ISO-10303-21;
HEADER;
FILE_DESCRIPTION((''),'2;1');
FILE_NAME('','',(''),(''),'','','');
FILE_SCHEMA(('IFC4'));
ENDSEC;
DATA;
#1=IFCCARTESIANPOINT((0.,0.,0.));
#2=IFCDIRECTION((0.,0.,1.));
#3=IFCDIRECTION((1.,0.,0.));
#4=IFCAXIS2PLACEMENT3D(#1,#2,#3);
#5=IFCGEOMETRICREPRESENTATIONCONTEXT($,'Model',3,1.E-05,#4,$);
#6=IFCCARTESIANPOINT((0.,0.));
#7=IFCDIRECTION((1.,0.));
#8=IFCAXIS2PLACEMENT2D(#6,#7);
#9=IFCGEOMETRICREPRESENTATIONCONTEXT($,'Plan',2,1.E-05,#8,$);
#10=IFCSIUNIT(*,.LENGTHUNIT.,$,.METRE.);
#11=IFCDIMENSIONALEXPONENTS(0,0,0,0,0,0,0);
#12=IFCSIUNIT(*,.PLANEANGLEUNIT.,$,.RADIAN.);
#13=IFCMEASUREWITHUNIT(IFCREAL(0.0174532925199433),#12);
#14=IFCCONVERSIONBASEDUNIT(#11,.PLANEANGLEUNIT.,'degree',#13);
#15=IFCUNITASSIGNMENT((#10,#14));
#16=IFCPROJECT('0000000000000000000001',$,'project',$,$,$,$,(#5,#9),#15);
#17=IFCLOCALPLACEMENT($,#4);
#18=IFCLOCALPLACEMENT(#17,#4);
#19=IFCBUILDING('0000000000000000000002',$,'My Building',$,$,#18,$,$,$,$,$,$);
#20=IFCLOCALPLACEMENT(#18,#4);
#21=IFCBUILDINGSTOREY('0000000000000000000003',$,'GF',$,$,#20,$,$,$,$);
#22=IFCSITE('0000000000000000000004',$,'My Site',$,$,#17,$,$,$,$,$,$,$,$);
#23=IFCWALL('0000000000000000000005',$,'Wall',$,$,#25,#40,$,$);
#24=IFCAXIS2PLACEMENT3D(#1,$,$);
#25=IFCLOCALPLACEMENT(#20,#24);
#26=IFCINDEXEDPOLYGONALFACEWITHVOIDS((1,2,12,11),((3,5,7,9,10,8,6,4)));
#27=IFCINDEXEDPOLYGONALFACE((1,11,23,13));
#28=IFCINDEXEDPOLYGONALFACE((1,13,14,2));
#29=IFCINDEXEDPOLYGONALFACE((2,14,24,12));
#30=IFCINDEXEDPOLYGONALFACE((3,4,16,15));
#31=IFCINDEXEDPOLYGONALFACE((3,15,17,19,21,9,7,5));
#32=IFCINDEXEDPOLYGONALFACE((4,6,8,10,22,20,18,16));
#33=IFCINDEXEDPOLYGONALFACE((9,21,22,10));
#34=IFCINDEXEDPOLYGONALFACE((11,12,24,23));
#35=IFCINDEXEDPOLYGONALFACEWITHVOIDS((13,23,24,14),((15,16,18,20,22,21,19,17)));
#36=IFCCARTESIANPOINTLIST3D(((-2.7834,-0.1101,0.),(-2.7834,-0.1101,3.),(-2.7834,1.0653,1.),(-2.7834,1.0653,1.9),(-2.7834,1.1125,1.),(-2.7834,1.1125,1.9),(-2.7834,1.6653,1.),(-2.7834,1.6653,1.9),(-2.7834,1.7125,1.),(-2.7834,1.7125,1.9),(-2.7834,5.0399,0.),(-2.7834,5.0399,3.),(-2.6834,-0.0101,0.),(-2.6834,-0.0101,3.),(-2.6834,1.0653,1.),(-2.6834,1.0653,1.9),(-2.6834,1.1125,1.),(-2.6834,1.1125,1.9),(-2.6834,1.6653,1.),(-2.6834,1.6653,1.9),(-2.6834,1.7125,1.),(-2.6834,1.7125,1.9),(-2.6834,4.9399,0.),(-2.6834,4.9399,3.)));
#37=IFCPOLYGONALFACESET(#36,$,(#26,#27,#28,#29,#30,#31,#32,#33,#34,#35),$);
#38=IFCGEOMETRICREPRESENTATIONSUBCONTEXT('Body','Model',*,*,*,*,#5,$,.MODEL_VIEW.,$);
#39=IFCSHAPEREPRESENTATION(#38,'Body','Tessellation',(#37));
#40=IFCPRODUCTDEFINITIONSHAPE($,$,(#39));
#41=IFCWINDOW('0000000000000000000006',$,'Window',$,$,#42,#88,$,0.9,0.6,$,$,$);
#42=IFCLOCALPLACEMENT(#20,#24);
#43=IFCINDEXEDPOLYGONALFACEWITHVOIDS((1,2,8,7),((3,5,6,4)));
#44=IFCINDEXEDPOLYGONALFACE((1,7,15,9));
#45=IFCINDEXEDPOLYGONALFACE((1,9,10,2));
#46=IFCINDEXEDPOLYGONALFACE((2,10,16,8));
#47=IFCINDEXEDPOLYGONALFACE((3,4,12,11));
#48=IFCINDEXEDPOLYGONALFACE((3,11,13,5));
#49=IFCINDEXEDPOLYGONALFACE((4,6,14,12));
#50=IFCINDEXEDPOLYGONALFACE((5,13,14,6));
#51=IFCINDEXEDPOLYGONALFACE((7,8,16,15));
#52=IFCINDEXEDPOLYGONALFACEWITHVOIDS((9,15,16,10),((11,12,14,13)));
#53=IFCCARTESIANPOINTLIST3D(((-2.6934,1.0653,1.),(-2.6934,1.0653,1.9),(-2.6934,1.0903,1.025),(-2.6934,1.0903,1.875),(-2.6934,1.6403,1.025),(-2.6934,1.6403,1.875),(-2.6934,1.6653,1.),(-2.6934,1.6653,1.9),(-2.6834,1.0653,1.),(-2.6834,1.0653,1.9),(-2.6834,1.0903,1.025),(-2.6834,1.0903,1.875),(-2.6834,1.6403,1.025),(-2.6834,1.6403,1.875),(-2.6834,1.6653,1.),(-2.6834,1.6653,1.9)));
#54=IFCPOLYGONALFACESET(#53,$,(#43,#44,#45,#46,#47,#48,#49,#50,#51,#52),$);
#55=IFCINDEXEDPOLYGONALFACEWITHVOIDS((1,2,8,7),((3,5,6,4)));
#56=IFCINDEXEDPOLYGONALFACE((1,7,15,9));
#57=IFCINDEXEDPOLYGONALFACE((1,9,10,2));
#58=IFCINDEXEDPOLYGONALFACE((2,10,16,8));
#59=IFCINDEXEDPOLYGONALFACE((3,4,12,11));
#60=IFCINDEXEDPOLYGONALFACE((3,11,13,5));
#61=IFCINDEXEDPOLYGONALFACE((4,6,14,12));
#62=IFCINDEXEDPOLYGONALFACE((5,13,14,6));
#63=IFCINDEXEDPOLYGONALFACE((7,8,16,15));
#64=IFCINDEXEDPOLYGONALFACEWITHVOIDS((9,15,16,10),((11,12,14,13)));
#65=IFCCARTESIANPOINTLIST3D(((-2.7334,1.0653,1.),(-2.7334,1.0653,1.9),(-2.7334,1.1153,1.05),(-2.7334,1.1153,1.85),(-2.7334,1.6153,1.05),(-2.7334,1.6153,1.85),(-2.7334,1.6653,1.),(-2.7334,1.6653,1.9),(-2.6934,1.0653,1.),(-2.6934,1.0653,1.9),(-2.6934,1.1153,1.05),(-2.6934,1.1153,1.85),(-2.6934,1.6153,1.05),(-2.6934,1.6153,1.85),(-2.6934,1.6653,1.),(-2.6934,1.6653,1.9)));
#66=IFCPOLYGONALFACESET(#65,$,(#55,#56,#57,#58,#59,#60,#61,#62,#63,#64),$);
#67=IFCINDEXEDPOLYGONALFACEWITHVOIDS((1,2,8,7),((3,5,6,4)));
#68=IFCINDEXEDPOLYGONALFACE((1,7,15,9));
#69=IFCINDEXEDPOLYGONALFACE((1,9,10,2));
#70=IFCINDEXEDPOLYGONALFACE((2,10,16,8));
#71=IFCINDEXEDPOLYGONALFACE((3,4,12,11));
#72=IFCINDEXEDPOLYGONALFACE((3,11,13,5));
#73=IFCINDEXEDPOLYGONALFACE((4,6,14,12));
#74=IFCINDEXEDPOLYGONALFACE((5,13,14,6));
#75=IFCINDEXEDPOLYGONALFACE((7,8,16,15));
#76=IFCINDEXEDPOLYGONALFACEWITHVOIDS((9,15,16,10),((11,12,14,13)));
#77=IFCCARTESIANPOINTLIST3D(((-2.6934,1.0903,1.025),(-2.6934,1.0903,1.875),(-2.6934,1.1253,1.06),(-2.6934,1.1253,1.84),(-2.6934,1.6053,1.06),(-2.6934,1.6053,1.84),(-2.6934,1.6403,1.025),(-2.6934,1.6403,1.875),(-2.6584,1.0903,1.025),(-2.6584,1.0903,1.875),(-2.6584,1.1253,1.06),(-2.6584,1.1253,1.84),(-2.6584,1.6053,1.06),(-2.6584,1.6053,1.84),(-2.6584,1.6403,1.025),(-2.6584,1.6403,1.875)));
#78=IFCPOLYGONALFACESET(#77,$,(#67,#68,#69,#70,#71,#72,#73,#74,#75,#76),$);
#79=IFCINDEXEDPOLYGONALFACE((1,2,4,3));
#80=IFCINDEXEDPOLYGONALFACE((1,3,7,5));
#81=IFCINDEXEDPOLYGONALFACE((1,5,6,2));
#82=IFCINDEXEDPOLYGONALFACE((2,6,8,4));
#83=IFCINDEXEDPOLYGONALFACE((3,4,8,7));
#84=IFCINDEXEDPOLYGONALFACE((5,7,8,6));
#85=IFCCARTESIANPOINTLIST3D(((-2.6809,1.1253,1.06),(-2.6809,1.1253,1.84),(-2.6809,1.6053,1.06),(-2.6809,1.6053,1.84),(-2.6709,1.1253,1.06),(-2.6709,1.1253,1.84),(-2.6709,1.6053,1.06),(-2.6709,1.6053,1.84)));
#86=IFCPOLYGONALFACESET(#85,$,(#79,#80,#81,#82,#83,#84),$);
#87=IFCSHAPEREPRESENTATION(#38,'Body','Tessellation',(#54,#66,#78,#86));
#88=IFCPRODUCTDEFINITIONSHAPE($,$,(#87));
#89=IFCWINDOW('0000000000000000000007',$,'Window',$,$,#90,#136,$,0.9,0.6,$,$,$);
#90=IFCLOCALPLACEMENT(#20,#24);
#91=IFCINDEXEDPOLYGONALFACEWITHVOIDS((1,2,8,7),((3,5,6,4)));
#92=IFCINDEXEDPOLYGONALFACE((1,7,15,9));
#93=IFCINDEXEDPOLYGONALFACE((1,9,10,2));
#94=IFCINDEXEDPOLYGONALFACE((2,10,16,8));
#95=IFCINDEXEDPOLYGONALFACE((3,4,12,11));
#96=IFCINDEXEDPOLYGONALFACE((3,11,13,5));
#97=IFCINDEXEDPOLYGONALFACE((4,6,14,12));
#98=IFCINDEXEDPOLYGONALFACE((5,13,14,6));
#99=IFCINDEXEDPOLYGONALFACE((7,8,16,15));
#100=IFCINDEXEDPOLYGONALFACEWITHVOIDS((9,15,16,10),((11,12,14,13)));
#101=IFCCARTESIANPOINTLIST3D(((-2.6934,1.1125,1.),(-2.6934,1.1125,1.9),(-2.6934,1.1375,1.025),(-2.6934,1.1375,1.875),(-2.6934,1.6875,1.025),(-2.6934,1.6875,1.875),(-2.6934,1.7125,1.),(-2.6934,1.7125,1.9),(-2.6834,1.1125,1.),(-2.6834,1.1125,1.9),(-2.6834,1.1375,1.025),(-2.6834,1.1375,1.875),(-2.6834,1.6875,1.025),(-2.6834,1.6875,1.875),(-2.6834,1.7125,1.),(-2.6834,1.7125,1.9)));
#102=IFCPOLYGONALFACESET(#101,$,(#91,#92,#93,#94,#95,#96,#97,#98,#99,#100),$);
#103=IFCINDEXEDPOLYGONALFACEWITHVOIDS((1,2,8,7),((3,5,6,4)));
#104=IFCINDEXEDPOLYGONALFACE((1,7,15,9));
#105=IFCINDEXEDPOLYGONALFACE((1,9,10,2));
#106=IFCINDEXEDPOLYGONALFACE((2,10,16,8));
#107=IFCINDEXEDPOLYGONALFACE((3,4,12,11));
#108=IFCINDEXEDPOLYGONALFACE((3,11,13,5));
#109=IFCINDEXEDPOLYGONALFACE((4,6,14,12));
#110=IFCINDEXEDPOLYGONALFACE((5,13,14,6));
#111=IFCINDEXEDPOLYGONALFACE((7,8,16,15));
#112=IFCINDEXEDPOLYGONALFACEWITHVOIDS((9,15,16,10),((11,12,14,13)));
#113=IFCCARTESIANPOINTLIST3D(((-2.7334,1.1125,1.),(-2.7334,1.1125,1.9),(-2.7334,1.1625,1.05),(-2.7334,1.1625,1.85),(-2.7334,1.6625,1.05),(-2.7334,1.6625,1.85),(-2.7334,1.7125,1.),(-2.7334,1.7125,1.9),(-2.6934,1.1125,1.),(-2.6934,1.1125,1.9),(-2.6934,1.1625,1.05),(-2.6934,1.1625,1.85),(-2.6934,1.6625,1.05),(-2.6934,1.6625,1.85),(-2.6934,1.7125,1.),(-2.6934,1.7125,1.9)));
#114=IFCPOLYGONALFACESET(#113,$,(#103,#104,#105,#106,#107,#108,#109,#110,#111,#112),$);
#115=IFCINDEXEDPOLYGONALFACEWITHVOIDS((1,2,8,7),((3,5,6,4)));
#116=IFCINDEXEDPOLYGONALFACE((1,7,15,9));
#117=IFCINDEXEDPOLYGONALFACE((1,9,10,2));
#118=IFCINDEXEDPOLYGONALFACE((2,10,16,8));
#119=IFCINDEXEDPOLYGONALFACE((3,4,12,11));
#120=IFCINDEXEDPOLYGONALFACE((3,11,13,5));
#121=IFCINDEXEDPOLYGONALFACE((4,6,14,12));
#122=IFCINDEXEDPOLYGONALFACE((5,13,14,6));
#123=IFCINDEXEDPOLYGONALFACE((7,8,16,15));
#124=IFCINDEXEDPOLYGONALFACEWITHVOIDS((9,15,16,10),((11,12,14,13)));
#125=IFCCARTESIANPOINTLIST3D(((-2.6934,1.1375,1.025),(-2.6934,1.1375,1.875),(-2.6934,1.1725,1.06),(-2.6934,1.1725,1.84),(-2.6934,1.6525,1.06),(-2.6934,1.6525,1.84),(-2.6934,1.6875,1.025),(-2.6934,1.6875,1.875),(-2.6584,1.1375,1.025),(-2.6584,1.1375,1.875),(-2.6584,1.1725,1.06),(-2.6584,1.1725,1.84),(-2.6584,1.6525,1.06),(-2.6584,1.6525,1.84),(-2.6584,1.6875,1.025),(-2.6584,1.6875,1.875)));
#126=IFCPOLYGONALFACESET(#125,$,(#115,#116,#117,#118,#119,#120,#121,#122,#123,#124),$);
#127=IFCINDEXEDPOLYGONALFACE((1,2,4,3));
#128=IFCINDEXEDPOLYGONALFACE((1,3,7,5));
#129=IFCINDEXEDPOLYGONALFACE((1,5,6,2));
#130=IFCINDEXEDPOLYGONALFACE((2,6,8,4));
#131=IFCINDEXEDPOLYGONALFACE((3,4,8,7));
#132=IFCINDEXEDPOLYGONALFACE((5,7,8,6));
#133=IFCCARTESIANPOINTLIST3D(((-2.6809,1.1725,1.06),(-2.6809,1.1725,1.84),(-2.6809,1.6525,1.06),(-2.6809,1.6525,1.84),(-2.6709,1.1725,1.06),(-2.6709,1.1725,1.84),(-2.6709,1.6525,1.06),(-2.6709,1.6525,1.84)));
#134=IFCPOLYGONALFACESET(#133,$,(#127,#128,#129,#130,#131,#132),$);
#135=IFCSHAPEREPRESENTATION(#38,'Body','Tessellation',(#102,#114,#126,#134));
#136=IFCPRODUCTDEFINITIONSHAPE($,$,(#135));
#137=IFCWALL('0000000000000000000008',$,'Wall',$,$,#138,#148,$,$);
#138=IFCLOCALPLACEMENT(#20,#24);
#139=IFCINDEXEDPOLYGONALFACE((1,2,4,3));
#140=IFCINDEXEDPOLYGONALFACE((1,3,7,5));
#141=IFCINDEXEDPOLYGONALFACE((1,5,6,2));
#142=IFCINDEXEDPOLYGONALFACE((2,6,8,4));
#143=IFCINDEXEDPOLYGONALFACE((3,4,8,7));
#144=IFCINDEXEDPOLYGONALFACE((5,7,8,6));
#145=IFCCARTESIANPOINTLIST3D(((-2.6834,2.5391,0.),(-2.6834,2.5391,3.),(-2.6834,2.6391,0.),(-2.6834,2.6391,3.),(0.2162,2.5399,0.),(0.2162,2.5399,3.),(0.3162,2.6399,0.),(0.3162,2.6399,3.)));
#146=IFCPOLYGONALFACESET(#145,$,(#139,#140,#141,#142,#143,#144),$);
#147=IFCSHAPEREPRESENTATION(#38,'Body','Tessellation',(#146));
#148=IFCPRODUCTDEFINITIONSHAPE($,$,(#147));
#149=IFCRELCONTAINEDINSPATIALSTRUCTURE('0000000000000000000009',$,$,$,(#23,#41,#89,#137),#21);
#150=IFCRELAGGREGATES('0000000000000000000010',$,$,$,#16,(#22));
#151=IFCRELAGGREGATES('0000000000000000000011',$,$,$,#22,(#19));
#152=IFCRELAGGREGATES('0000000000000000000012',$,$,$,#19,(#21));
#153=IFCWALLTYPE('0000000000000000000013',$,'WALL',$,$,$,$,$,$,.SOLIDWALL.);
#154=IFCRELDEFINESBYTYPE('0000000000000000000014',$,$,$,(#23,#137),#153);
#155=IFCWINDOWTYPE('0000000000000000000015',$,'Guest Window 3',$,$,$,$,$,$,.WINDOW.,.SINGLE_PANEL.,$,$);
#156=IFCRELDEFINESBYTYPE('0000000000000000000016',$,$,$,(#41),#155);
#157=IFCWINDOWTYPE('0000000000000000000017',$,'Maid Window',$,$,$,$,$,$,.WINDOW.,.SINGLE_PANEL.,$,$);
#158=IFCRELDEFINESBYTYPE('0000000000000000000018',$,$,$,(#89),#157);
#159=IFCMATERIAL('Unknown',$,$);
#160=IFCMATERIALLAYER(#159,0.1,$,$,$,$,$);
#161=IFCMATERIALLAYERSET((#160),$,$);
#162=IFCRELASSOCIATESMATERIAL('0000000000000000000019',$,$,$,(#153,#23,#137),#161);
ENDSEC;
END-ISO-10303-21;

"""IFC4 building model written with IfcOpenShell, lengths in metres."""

from ifc_helpers import new_model, entity, si_unit, converted_unit, frame, origin_with_axes, origin_2d_with_axis, place, context, subcontext, project, spatial, line, indexed_curve, outline, extrude, shape, source, transform, mapped, material, layer, layer_set, layer_usage, type_object, type_shapes, element, fill, save


model = new_model("IFC4")

# Units and contexts
model_context = context("Model", 3, precision=1e-05, world=origin_with_axes())
plan_context = context("Plan", 2, precision=1e-05, world=origin_2d_with_axis())
body_context_1 = subcontext(model_context, "Body", "Model", "MODEL_VIEW")
body_context_2 = subcontext(plan_context, "Body", "Plan", "PLAN_VIEW")
ifc_project = project(units=[si_unit("LENGTHUNIT", "METRE"), converted_unit("PLANEANGLEUNIT", "degree", entity("IfcReal", 0.0174532925199433), si_unit("PLANEANGLEUNIT", "RADIAN"), dimensions=[0, 0, 0, 0, 0, 0, 0])], contexts=[model_context, plan_context])

# Site, building, storey
site_placement = place(None, origin_with_axes())
site = spatial("IfcSite", under=ifc_project, at=site_placement, Name="My Site")
building_placement = place(site_placement, origin_with_axes())
building = spatial("IfcBuilding", under=site, at=building_placement, Name="My Building")
storey_placement = place(building_placement, origin_with_axes())
storey = spatial("IfcBuildingStorey", under=building, at=storey_placement, Name="GF")

# Shared definitions
ifc_material = material(Name="Unknown")
ifc_layer = layer(ifc_material, 0.1)
ifc_layer_set = layer_set([ifc_layer])
wall_type = type_object("IfcWallType", Name="WALL", PredefinedType="SOLIDWALL", material=ifc_layer_set)

# Wall, openings, windows
shared_shape_1 = source(origin_with_axes(), body_context_1, "Body", "SweptSolid", [
    extrude(outline(indexed_curve([(0.0, 0.0), (0.6, 0.0), (0.6, 0.9), (0.0, 0.9)], segments=[line(1, 2, 3, 4, 1)])), frame((0.0, -0.6, 0.0), z_axis=(0.0, -1.0, 0.0), x_axis=(1.0, 0.0, 0.0)), (0.0, 0.0, -1.0), 1.2),
])
window_type_1 = type_object("IfcWindowType", Name="Maid Window", PartitioningType="SINGLE_PANEL", PredefinedType="WINDOW")
shared_shape_2 = source(origin_with_axes(), body_context_1, "Body", "SweptSolid", [
    extrude(outline(indexed_curve([(0.0, 0.0), (0.6, 0.0), (0.6, 0.9), (0.0, 0.9)], segments=[line(1, 2, 3, 4, 1)]), holes=[indexed_curve([(0.025, 0.025), (0.575, 0.025), (0.575, 0.875), (0.025, 0.875)], segments=[line(1, 2, 3, 4, 1)])]), frame((0.0, 0.09, 0.0), z_axis=(0.0, -1.0, 0.0), x_axis=(1.0, 0.0, 0.0)), (0.0, 0.0, -1.0), 0.01),
    extrude(outline(indexed_curve([(0.0, 0.0), (0.6, 0.0), (0.6, 0.9), (0.0, 0.9)], segments=[line(1, 2, 3, 4, 1)]), holes=[indexed_curve([(0.05, 0.05), (0.55, 0.05), (0.55, 0.85), (0.05, 0.85)], segments=[line(1, 2, 3, 4, 1)])]), frame((0.0, 0.05, 0.0), z_axis=(0.0, -1.0, 0.0), x_axis=(1.0, 0.0, 0.0)), (0.0, 0.0, -1.0), 0.04),
    extrude(outline(indexed_curve([(0.0, 0.0), (0.55, 0.0), (0.55, 0.85), (0.0, 0.85)], segments=[line(1, 2, 3, 4, 1)]), holes=[indexed_curve([(0.035, 0.035), (0.515, 0.035), (0.515, 0.815), (0.035, 0.815)], segments=[line(1, 2, 3, 4, 1)])]), frame((0.025, 0.09, 0.025), z_axis=(0.0, -1.0, 0.0), x_axis=(1.0, 0.0, 0.0)), (0.0, 0.0, -1.0), 0.035),
    extrude(outline(indexed_curve([(0.035, 0.035), (0.515, 0.035), (0.515, 0.815), (0.035, 0.815)], segments=[line(1, 2, 3, 4, 1)])), frame((0.025, 0.1025, 0.025), z_axis=(0.0, -1.0, 0.0), x_axis=(1.0, 0.0, 0.0)), (0.0, 0.0, -1.0), 0.01),
])
shared_shape_3 = source(origin_with_axes(), body_context_2, "Body", "Curve2D", [
    entity("IfcIndexedPolyCurve", entity("IfcCartesianPointList2D", [[0.05, 0.05], [0.55, 0.05]])),
    entity("IfcIndexedPolyCurve", entity("IfcCartesianPointList2D", [[0.0, 0.1], [0.025, 0.1], [0.025, 0.09], [0.05, 0.09], [0.05, 0.05], [0.0, 0.05]]), [entity("IfcLineIndex", [1, 2, 3, 4, 5, 6, 1])]),
    entity("IfcIndexedPolyCurve", entity("IfcCartesianPointList2D", [[0.6, 0.1], [0.575, 0.1], [0.575, 0.09], [0.55, 0.09], [0.55, 0.05], [0.6, 0.05]]), [entity("IfcLineIndex", [1, 2, 3, 4, 5, 6, 1])]),
    entity("IfcIndexedPolyCurve", entity("IfcCartesianPointList2D", [[0.025, 0.09], [0.06, 0.09], [0.06, 0.125], [0.025, 0.125]]), [entity("IfcLineIndex", [1, 2, 3, 4, 1])]),
    entity("IfcIndexedPolyCurve", entity("IfcCartesianPointList2D", [[0.575, 0.09], [0.54, 0.09], [0.54, 0.125], [0.575, 0.125]]), [entity("IfcLineIndex", [1, 2, 3, 4, 1])]),
    entity("IfcIndexedPolyCurve", entity("IfcCartesianPointList2D", [[0.06, 0.09], [0.54, 0.09]])),
    entity("IfcIndexedPolyCurve", entity("IfcCartesianPointList2D", [[0.06, 0.125], [0.54, 0.125]])),
    entity("IfcIndexedPolyCurve", entity("IfcCartesianPointList2D", [[0.06, 0.1075], [0.54, 0.1075]])),
])
type_shapes(window_type_1, [shared_shape_2, shared_shape_3])
ifc_layer_usage_1 = layer_usage(ifc_layer_set, "AXIS2", "POSITIVE", 0.0)
wall_1_placement = place(storey_placement, frame((-2.7834, 5.0399, 0.0), z_axis=(0.0, 0.0, 1.0), x_axis=(0.0, -1.0, 0.0)))
wall_1 = element("IfcWall", 1, at=wall_1_placement, inside=storey, type_object=wall_type, material=ifc_layer_usage_1, Name="Wall", context=body_context_1, shape_type="SweptSolid", body=[
    extrude(outline(indexed_curve([(0.0, 0.0), (0.1, 0.1), (5.05, 0.1), (5.15, 0.0)], segments=[line(1, 2, 3, 4, 1)])), origin_with_axes(), (0.0, 0.0, 1.0), 3.0),
])
opening_1_placement = place(wall_1_placement, frame((3.3274, 0.0, 1.0), z_axis=(0.0, 0.0, 1.0), x_axis=(1.0, 0.0, 0.0)))
opening_1 = element("IfcOpeningElement", 2, at=opening_1_placement, cuts=wall_1, PredefinedType="OPENING", context=body_context_1, shape_type="MappedRepresentation", body=[
    mapped(shared_shape_1, transform((0.0, 0.0, 0.0), x_axis=(1.0, 0.0, 0.0), y_axis=(0.0, 1.0, 0.0), z_axis=(0.0, 0.0, 1.0), scale=1.0)),
])
shared_shape_4 = source(origin_with_axes(), body_context_1, "Body", "SweptSolid", [
    extrude(outline(indexed_curve([(0.0, 0.0), (0.6, 0.0), (0.6, 0.9), (0.0, 0.9)], segments=[line(1, 2, 3, 4, 1)])), frame((0.0, -0.6, 0.0), z_axis=(0.0, -1.0, 0.0), x_axis=(1.0, 0.0, 0.0)), (0.0, 0.0, -1.0), 1.2),
])
opening_2_placement = place(wall_1_placement, frame((3.3746, 0.0, 1.0), z_axis=(0.0, 0.0, 1.0), x_axis=(1.0, 0.0, 0.0)))
opening_2 = element("IfcOpeningElement", 3, at=opening_2_placement, cuts=wall_1, PredefinedType="OPENING", context=body_context_1, shape_type="MappedRepresentation", body=[
    mapped(shared_shape_4, transform((0.0, 0.0, 0.0), x_axis=(1.0, 0.0, 0.0), y_axis=(0.0, 1.0, 0.0), z_axis=(0.0, 0.0, 1.0), scale=1.0)),
])
window_type_2 = type_object("IfcWindowType", Name="Guest Window 3", PartitioningType="SINGLE_PANEL", PredefinedType="WINDOW")
shared_shape_5 = source(origin_with_axes(), body_context_1, "Body", "SweptSolid", [
    extrude(outline(indexed_curve([(0.0, 0.0), (0.6, 0.0), (0.6, 0.9), (0.0, 0.9)], segments=[line(1, 2, 3, 4, 1)]), holes=[indexed_curve([(0.025, 0.025), (0.575, 0.025), (0.575, 0.875), (0.025, 0.875)], segments=[line(1, 2, 3, 4, 1)])]), frame((0.0, 0.09, 0.0), z_axis=(0.0, -1.0, 0.0), x_axis=(1.0, 0.0, 0.0)), (0.0, 0.0, -1.0), 0.01),
    extrude(outline(indexed_curve([(0.0, 0.0), (0.6, 0.0), (0.6, 0.9), (0.0, 0.9)], segments=[line(1, 2, 3, 4, 1)]), holes=[indexed_curve([(0.05, 0.05), (0.55, 0.05), (0.55, 0.85), (0.05, 0.85)], segments=[line(1, 2, 3, 4, 1)])]), frame((0.0, 0.05, 0.0), z_axis=(0.0, -1.0, 0.0), x_axis=(1.0, 0.0, 0.0)), (0.0, 0.0, -1.0), 0.04),
    extrude(outline(indexed_curve([(0.0, 0.0), (0.55, 0.0), (0.55, 0.85), (0.0, 0.85)], segments=[line(1, 2, 3, 4, 1)]), holes=[indexed_curve([(0.035, 0.035), (0.515, 0.035), (0.515, 0.815), (0.035, 0.815)], segments=[line(1, 2, 3, 4, 1)])]), frame((0.025, 0.09, 0.025), z_axis=(0.0, -1.0, 0.0), x_axis=(1.0, 0.0, 0.0)), (0.0, 0.0, -1.0), 0.035),
    extrude(outline(indexed_curve([(0.035, 0.035), (0.515, 0.035), (0.515, 0.815), (0.035, 0.815)], segments=[line(1, 2, 3, 4, 1)])), frame((0.025, 0.1025, 0.025), z_axis=(0.0, -1.0, 0.0), x_axis=(1.0, 0.0, 0.0)), (0.0, 0.0, -1.0), 0.01),
])
shared_shape_6 = source(origin_with_axes(), body_context_2, "Body", "Curve2D", [
    entity("IfcIndexedPolyCurve", entity("IfcCartesianPointList2D", [[0.05, 0.05], [0.55, 0.05]])),
    entity("IfcIndexedPolyCurve", entity("IfcCartesianPointList2D", [[0.0, 0.1], [0.025, 0.1], [0.025, 0.09], [0.05, 0.09], [0.05, 0.05], [0.0, 0.05]]), [entity("IfcLineIndex", [1, 2, 3, 4, 5, 6, 1])]),
    entity("IfcIndexedPolyCurve", entity("IfcCartesianPointList2D", [[0.6, 0.1], [0.575, 0.1], [0.575, 0.09], [0.55, 0.09], [0.55, 0.05], [0.6, 0.05]]), [entity("IfcLineIndex", [1, 2, 3, 4, 5, 6, 1])]),
    entity("IfcIndexedPolyCurve", entity("IfcCartesianPointList2D", [[0.025, 0.09], [0.06, 0.09], [0.06, 0.125], [0.025, 0.125]]), [entity("IfcLineIndex", [1, 2, 3, 4, 1])]),
    entity("IfcIndexedPolyCurve", entity("IfcCartesianPointList2D", [[0.575, 0.09], [0.54, 0.09], [0.54, 0.125], [0.575, 0.125]]), [entity("IfcLineIndex", [1, 2, 3, 4, 1])]),
    entity("IfcIndexedPolyCurve", entity("IfcCartesianPointList2D", [[0.06, 0.09], [0.54, 0.09]])),
    entity("IfcIndexedPolyCurve", entity("IfcCartesianPointList2D", [[0.06, 0.125], [0.54, 0.125]])),
    entity("IfcIndexedPolyCurve", entity("IfcCartesianPointList2D", [[0.06, 0.1075], [0.54, 0.1075]])),
])
type_shapes(window_type_2, [shared_shape_5, shared_shape_6])
window_1_placement = place(opening_2_placement, frame((0.0, 0.0, 0.0), z_axis=(0.0, 0.0, 1.0), x_axis=(1.0, 0.0, 0.0)))
window_1 = element("IfcWindow", 4, at=window_1_placement, inside=storey, type_object=window_type_2, Name="Window", OverallHeight=0.9, OverallWidth=0.6, shapes=[
    shape(body_context_1, "Body", "MappedRepresentation", [mapped(shared_shape_5, transform((0.0, 0.0, 0.0), x_axis=(1.0, 0.0, 0.0), y_axis=(0.0, 1.0, 0.0), z_axis=(0.0, 0.0, 1.0), scale=1.0))]),
    shape(body_context_2, "Body", "MappedRepresentation", [mapped(shared_shape_6, transform((0.0, 0.0, 0.0), x_axis=(1.0, 0.0, 0.0), y_axis=(0.0, 1.0, 0.0), z_axis=(0.0, 0.0, 1.0), scale=1.0))]),
])
fill(opening_2, window_1)
window_2_placement = place(opening_1_placement, frame((0.0, 0.0, 0.0), z_axis=(0.0, 0.0, 1.0), x_axis=(1.0, 0.0, 0.0)))
window_2 = element("IfcWindow", 5, at=window_2_placement, inside=storey, type_object=window_type_1, Name="Window", OverallHeight=0.9, OverallWidth=0.6, shapes=[
    shape(body_context_1, "Body", "MappedRepresentation", [mapped(shared_shape_2, transform((0.0, 0.0, 0.0), x_axis=(1.0, 0.0, 0.0), y_axis=(0.0, 1.0, 0.0), z_axis=(0.0, 0.0, 1.0), scale=1.0))]),
    shape(body_context_2, "Body", "MappedRepresentation", [mapped(shared_shape_3, transform((0.0, 0.0, 0.0), x_axis=(1.0, 0.0, 0.0), y_axis=(0.0, 1.0, 0.0), z_axis=(0.0, 0.0, 1.0), scale=1.0))]),
])
fill(opening_1, window_2)

# Wall
ifc_layer_usage_2 = layer_usage(ifc_layer_set, "AXIS2", "POSITIVE", 0.0)
wall_2_placement = place(storey_placement, frame((0.3162, 2.6399, 0.0), z_axis=(0.0, 0.0, 1.0), x_axis=(-1.0, -0.00025, 0.0)))
element("IfcWall", 6, at=wall_2_placement, inside=storey, type_object=wall_type, material=ifc_layer_usage_2, Name="Wall", context=body_context_1, shape_type="SweptSolid", body=[
    extrude(outline(indexed_curve([(0.0, 0.0), (0.1, 0.1), (2.9996, 0.1), (2.9996, 0.0)], segments=[line(1, 2, 3, 4, 1)])), origin_with_axes(), (0.0, 0.0, 1.0), 3.0),
])

save(model, "model.ifc")
